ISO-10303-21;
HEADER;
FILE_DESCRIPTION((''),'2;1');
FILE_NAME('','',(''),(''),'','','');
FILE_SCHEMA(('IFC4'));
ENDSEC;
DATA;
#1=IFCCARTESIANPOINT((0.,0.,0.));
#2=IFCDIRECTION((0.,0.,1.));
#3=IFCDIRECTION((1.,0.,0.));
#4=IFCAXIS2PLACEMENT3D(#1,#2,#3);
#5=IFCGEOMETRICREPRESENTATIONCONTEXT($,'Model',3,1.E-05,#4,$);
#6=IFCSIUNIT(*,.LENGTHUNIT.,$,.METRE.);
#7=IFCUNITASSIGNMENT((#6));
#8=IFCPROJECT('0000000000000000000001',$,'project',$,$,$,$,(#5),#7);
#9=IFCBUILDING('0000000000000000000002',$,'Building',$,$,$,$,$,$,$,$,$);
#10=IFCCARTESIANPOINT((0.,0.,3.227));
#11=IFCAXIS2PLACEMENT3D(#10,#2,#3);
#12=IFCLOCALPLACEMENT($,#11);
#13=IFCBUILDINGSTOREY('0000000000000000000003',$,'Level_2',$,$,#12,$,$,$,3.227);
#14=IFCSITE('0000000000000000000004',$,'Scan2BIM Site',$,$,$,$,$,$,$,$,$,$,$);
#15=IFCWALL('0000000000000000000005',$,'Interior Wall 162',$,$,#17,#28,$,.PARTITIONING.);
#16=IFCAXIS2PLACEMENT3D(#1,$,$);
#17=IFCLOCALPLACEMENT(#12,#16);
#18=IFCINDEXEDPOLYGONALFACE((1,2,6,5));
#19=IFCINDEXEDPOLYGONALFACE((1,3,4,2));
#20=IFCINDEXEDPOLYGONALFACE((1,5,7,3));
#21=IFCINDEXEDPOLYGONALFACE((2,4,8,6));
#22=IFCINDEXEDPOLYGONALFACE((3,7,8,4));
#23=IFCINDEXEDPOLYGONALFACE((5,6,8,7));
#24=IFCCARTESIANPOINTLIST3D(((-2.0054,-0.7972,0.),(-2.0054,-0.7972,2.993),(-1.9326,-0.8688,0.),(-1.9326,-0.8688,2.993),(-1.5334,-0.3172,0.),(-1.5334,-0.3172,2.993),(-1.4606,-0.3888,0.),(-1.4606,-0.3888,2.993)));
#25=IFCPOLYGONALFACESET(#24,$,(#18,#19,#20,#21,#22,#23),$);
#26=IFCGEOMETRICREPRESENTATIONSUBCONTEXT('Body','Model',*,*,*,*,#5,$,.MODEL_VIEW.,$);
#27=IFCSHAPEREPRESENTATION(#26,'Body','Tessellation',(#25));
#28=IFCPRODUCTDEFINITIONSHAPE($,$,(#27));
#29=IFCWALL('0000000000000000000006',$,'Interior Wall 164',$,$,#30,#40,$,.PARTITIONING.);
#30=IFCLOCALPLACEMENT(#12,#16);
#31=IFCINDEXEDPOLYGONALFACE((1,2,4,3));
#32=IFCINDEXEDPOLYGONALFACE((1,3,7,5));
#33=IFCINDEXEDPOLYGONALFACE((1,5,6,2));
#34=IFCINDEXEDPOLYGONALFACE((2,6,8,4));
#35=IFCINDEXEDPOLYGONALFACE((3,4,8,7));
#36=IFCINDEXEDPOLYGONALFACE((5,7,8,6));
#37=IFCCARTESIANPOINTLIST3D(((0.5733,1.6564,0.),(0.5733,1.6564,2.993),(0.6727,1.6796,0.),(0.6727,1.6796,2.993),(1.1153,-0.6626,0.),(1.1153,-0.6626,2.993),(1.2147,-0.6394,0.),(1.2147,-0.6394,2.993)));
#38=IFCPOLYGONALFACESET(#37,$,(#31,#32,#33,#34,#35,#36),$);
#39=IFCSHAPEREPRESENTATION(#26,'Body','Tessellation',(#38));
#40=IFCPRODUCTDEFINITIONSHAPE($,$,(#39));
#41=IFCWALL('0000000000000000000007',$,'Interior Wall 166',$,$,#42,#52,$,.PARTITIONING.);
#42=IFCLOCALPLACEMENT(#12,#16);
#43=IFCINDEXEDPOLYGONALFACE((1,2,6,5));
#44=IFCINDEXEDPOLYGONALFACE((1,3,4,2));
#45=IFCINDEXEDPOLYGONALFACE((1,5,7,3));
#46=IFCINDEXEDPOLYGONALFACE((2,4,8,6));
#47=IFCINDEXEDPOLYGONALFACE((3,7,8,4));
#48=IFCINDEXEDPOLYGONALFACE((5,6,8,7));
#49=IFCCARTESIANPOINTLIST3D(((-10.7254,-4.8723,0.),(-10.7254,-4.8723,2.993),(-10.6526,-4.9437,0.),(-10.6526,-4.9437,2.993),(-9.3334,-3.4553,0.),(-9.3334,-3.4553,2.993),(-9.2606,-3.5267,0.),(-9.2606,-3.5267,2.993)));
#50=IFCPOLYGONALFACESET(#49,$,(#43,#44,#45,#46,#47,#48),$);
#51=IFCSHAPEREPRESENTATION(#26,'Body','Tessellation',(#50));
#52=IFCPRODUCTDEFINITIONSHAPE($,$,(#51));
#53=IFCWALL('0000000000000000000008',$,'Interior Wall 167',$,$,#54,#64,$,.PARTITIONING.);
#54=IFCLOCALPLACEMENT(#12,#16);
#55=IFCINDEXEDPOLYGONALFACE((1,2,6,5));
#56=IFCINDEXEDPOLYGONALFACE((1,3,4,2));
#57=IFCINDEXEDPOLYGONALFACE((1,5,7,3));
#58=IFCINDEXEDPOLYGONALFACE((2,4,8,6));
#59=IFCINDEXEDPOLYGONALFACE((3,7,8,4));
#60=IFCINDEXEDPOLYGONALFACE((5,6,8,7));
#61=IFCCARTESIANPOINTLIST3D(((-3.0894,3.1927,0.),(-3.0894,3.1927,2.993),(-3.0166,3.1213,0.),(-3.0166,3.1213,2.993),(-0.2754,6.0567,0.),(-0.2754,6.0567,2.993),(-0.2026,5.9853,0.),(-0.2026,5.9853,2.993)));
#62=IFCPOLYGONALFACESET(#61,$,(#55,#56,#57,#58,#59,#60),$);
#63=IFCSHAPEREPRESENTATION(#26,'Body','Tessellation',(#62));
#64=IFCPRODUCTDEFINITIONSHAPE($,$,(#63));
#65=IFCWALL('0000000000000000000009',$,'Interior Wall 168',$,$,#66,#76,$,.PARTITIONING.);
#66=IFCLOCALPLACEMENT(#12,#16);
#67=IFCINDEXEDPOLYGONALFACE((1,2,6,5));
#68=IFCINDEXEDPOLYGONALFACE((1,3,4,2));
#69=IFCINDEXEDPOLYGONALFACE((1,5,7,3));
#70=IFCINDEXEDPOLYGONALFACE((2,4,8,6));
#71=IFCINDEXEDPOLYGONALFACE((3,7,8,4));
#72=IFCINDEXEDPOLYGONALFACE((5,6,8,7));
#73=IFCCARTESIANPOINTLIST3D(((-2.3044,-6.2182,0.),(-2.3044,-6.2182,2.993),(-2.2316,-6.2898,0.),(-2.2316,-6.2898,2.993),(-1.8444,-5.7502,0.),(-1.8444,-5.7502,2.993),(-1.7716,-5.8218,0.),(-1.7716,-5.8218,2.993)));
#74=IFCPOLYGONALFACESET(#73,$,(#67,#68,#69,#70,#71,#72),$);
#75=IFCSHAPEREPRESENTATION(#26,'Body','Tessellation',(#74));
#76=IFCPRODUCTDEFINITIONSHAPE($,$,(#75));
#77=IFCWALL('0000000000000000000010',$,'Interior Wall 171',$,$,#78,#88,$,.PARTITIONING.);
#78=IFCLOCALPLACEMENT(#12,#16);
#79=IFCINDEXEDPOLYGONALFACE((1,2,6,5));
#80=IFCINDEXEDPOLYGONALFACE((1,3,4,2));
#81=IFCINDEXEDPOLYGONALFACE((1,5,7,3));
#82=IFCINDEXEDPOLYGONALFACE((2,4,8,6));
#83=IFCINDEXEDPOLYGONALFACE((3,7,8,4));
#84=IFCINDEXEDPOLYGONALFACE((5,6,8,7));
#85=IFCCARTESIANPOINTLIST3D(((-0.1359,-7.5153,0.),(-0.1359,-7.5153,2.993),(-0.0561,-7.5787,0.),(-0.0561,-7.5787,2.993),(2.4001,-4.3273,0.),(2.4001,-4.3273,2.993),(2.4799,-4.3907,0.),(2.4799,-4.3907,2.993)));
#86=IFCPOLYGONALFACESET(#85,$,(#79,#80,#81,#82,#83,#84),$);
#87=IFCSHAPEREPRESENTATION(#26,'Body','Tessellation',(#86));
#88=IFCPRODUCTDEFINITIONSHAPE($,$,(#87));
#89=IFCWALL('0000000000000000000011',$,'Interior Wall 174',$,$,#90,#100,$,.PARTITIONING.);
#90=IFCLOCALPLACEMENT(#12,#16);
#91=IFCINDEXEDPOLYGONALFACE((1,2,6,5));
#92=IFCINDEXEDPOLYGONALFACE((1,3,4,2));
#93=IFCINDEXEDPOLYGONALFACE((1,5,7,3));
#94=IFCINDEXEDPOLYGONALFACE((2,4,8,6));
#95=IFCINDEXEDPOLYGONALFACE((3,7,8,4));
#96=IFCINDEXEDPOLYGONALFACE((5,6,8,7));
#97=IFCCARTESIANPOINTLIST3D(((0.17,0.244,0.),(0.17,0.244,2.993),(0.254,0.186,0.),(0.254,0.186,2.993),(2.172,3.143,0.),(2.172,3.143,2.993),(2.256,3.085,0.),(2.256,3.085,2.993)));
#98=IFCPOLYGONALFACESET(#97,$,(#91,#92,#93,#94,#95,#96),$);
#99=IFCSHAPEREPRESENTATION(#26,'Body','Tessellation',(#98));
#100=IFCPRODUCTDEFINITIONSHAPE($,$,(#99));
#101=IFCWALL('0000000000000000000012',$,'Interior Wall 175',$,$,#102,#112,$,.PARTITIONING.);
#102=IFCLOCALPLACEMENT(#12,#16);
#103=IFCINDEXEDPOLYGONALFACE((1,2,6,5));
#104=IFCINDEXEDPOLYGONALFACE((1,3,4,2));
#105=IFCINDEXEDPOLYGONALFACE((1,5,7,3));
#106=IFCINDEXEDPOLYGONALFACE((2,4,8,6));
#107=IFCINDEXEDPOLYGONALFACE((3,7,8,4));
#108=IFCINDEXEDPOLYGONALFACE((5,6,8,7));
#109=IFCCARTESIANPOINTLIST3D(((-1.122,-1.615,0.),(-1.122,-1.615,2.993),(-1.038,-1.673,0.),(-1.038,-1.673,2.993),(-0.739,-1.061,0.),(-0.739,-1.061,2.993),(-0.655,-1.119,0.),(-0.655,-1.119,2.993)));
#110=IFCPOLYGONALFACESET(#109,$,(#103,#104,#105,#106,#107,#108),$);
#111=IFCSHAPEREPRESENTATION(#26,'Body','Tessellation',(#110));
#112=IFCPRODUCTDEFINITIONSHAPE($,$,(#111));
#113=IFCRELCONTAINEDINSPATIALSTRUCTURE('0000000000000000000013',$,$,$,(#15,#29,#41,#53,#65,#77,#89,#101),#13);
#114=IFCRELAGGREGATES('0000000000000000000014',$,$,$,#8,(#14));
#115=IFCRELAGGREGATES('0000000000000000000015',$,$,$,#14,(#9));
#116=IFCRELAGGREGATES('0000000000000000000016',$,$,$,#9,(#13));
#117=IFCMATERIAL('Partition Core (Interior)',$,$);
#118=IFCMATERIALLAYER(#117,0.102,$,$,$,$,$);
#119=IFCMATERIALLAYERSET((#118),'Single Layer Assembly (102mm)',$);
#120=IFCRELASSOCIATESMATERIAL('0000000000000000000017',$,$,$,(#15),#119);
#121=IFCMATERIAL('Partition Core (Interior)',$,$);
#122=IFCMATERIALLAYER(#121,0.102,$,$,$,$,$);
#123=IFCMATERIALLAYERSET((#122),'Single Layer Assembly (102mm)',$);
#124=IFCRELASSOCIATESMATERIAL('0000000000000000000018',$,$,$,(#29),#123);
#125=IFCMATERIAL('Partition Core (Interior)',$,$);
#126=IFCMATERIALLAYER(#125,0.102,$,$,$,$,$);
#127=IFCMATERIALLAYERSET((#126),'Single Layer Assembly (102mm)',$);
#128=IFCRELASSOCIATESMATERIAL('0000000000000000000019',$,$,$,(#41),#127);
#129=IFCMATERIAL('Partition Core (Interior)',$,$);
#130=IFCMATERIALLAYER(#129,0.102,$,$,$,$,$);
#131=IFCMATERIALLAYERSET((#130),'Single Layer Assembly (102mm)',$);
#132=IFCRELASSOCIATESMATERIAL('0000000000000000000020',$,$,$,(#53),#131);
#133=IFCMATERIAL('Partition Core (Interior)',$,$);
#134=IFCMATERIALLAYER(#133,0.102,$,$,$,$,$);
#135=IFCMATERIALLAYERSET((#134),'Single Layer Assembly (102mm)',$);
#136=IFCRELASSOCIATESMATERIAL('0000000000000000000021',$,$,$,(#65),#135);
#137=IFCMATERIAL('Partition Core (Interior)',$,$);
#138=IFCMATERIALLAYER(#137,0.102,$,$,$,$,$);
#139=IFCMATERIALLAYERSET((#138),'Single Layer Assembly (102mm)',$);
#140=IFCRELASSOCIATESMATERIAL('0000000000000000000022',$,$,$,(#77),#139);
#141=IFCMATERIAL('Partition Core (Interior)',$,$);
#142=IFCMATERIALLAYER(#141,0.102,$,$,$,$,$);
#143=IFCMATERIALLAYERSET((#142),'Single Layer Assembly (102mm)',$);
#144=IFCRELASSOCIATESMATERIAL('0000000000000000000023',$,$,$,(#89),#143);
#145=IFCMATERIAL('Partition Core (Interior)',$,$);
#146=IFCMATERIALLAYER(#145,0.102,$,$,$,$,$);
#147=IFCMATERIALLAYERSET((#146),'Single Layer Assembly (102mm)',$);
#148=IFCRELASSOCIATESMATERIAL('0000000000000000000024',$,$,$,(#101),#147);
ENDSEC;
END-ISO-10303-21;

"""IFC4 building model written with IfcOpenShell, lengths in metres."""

from ifc_helpers import new_model, si_unit, frame, origin, origin_with_axes, place, context, subcontext, project, spatial, rectangle, extrude, material, layer, layer_set, element, save


model = new_model("IFC4")

# Units and contexts
model_context = context("Model", 3, precision=1e-05, world=origin_with_axes())
body_context = subcontext(model_context, "Body", "Model", "MODEL_VIEW")
ifc_project = project(units=[si_unit("LENGTHUNIT", "METRE")], contexts=[model_context])

# Site, building, storey
site = spatial("IfcSite", under=ifc_project, Name="Scan2BIM Site")
building = spatial("IfcBuilding", under=site, Name="Building")
storey_placement = place(None, frame((0.0, 0.0, 3.227), z_axis=(0.0, 0.0, 1.0), x_axis=(1.0, 0.0, 0.0)))
storey = spatial("IfcBuildingStorey", under=building, at=storey_placement, Name="Level_2", Elevation=3.227)

# Walls
ifc_material_1 = material(Name="Partition Core (Interior)")
ifc_layer_1 = layer(ifc_material_1, 0.102)
ifc_layer_set_1 = layer_set([ifc_layer_1], Name="Single Layer Assembly (102mm)")
wall_1_placement = place(storey_placement, frame((-1.733, -0.593, 0.0), z_axis=(0.0, 0.0, 1.0), x_axis=(0.70114, 0.713024, 0.0)))
element("IfcWall", 1, at=wall_1_placement, inside=storey, material=ifc_layer_set_1, Name="Interior Wall 162", PredefinedType="PARTITIONING", context=body_context, shape_type="SweptSolid", body=[
    extrude(rectangle(XDim=0.6732, YDim=0.102), origin(), (0.0, 0.0, 1.0), 2.993),
])
ifc_material_2 = material(Name="Partition Core (Interior)")
ifc_layer_2 = layer(ifc_material_2, 0.102)
ifc_layer_set_2 = layer_set([ifc_layer_2], Name="Single Layer Assembly (102mm)")
wall_2_placement = place(storey_placement, frame((0.894, 0.5085, 0.0), z_axis=(0.0, 0.0, 1.0), x_axis=(0.227588, -0.973758, 0.0)))
element("IfcWall", 2, at=wall_2_placement, inside=storey, material=ifc_layer_set_2, Name="Interior Wall 164", PredefinedType="PARTITIONING", context=body_context, shape_type="SweptSolid", body=[
    extrude(rectangle(XDim=2.3815, YDim=0.102), origin(), (0.0, 0.0, 1.0), 2.993),
])
ifc_material_3 = material(Name="Partition Core (Interior)")
ifc_layer_3 = layer(ifc_material_3, 0.102)
ifc_layer_set_3 = layer_set([ifc_layer_3], Name="Single Layer Assembly (102mm)")
wall_3_placement = place(storey_placement, frame((-9.993, -4.1995, 0.0), z_axis=(0.0, 0.0, 1.0), x_axis=(-0.700786, -0.713372, 0.0)))
element("IfcWall", 3, at=wall_3_placement, inside=storey, material=ifc_layer_set_3, Name="Interior Wall 166", PredefinedType="PARTITIONING", context=body_context, shape_type="SweptSolid", body=[
    extrude(rectangle(XDim=1.9863, YDim=0.102), origin(), (0.0, 0.0, 1.0), 2.993),
])
ifc_material_4 = material(Name="Partition Core (Interior)")
ifc_layer_4 = layer(ifc_material_4, 0.102)
ifc_layer_set_4 = layer_set([ifc_layer_4], Name="Single Layer Assembly (102mm)")
wall_4_placement = place(storey_placement, frame((-1.646, 4.589, 0.0), z_axis=(0.0, 0.0, 1.0), x_axis=(0.700853, 0.713306, 0.0)))
element("IfcWall", 4, at=wall_4_placement, inside=storey, material=ifc_layer_set_4, Name="Interior Wall 167", PredefinedType="PARTITIONING", context=body_context, shape_type="SweptSolid", body=[
    extrude(rectangle(XDim=4.0151, YDim=0.102), origin(), (0.0, 0.0, 1.0), 2.993),
])
ifc_material_5 = material(Name="Partition Core (Interior)")
ifc_layer_5 = layer(ifc_material_5, 0.102)
ifc_layer_set_5 = layer_set([ifc_layer_5], Name="Single Layer Assembly (102mm)")
wall_5_placement = place(storey_placement, frame((-2.038, -6.02, 0.0), z_axis=(0.0, 0.0, 1.0), x_axis=(0.700985, 0.713176, 0.0)))
element("IfcWall", 5, at=wall_5_placement, inside=storey, material=ifc_layer_set_5, Name="Interior Wall 168", PredefinedType="PARTITIONING", context=body_context, shape_type="SweptSolid", body=[
    extrude(rectangle(XDim=0.6562, YDim=0.102), origin(), (0.0, 0.0, 1.0), 2.993),
])
ifc_material_6 = material(Name="Partition Core (Interior)")
ifc_layer_6 = layer(ifc_material_6, 0.102)
ifc_layer_set_6 = layer_set([ifc_layer_6], Name="Single Layer Assembly (102mm)")
wall_6_placement = place(storey_placement, frame((1.172, -5.953, 0.0), z_axis=(0.0, 0.0, 1.0), x_axis=(-0.622537, -0.78259, 0.0)))
element("IfcWall", 6, at=wall_6_placement, inside=storey, material=ifc_layer_set_6, Name="Interior Wall 171", PredefinedType="PARTITIONING", context=body_context, shape_type="SweptSolid", body=[
    extrude(rectangle(XDim=4.0737, YDim=0.102), origin(), (0.0, 0.0, 1.0), 2.993),
])
ifc_material_7 = material(Name="Partition Core (Interior)")
ifc_layer_7 = layer(ifc_material_7, 0.102)
ifc_layer_set_7 = layer_set([ifc_layer_7], Name="Single Layer Assembly (102mm)")
wall_7_placement = place(storey_placement, frame((1.213, 1.6645, 0.0), z_axis=(0.0, 0.0, 1.0), x_axis=(-0.56825, -0.822856, 0.0)))
element("IfcWall", 7, at=wall_7_placement, inside=storey, material=ifc_layer_set_7, Name="Interior Wall 174", PredefinedType="PARTITIONING", context=body_context, shape_type="SweptSolid", body=[
    extrude(rectangle(XDim=3.5231, YDim=0.102), origin(), (0.0, 0.0, 1.0), 2.993),
])
ifc_material_8 = material(Name="Partition Core (Interior)")
ifc_layer_8 = layer(ifc_material_8, 0.102)
ifc_layer_set_8 = layer_set([ifc_layer_8], Name="Single Layer Assembly (102mm)")
wall_8_placement = place(storey_placement, frame((-0.8885, -1.367, 0.0), z_axis=(0.0, 0.0, 1.0), x_axis=(-0.568669, -0.822566, 0.0)))
element("IfcWall", 8, at=wall_8_placement, inside=storey, material=ifc_layer_set_8, Name="Interior Wall 175", PredefinedType="PARTITIONING", context=body_context, shape_type="SweptSolid", body=[
    extrude(rectangle(XDim=0.6735, YDim=0.102), origin(), (0.0, 0.0, 1.0), 2.993),
])

save(model, "model.ifc")
